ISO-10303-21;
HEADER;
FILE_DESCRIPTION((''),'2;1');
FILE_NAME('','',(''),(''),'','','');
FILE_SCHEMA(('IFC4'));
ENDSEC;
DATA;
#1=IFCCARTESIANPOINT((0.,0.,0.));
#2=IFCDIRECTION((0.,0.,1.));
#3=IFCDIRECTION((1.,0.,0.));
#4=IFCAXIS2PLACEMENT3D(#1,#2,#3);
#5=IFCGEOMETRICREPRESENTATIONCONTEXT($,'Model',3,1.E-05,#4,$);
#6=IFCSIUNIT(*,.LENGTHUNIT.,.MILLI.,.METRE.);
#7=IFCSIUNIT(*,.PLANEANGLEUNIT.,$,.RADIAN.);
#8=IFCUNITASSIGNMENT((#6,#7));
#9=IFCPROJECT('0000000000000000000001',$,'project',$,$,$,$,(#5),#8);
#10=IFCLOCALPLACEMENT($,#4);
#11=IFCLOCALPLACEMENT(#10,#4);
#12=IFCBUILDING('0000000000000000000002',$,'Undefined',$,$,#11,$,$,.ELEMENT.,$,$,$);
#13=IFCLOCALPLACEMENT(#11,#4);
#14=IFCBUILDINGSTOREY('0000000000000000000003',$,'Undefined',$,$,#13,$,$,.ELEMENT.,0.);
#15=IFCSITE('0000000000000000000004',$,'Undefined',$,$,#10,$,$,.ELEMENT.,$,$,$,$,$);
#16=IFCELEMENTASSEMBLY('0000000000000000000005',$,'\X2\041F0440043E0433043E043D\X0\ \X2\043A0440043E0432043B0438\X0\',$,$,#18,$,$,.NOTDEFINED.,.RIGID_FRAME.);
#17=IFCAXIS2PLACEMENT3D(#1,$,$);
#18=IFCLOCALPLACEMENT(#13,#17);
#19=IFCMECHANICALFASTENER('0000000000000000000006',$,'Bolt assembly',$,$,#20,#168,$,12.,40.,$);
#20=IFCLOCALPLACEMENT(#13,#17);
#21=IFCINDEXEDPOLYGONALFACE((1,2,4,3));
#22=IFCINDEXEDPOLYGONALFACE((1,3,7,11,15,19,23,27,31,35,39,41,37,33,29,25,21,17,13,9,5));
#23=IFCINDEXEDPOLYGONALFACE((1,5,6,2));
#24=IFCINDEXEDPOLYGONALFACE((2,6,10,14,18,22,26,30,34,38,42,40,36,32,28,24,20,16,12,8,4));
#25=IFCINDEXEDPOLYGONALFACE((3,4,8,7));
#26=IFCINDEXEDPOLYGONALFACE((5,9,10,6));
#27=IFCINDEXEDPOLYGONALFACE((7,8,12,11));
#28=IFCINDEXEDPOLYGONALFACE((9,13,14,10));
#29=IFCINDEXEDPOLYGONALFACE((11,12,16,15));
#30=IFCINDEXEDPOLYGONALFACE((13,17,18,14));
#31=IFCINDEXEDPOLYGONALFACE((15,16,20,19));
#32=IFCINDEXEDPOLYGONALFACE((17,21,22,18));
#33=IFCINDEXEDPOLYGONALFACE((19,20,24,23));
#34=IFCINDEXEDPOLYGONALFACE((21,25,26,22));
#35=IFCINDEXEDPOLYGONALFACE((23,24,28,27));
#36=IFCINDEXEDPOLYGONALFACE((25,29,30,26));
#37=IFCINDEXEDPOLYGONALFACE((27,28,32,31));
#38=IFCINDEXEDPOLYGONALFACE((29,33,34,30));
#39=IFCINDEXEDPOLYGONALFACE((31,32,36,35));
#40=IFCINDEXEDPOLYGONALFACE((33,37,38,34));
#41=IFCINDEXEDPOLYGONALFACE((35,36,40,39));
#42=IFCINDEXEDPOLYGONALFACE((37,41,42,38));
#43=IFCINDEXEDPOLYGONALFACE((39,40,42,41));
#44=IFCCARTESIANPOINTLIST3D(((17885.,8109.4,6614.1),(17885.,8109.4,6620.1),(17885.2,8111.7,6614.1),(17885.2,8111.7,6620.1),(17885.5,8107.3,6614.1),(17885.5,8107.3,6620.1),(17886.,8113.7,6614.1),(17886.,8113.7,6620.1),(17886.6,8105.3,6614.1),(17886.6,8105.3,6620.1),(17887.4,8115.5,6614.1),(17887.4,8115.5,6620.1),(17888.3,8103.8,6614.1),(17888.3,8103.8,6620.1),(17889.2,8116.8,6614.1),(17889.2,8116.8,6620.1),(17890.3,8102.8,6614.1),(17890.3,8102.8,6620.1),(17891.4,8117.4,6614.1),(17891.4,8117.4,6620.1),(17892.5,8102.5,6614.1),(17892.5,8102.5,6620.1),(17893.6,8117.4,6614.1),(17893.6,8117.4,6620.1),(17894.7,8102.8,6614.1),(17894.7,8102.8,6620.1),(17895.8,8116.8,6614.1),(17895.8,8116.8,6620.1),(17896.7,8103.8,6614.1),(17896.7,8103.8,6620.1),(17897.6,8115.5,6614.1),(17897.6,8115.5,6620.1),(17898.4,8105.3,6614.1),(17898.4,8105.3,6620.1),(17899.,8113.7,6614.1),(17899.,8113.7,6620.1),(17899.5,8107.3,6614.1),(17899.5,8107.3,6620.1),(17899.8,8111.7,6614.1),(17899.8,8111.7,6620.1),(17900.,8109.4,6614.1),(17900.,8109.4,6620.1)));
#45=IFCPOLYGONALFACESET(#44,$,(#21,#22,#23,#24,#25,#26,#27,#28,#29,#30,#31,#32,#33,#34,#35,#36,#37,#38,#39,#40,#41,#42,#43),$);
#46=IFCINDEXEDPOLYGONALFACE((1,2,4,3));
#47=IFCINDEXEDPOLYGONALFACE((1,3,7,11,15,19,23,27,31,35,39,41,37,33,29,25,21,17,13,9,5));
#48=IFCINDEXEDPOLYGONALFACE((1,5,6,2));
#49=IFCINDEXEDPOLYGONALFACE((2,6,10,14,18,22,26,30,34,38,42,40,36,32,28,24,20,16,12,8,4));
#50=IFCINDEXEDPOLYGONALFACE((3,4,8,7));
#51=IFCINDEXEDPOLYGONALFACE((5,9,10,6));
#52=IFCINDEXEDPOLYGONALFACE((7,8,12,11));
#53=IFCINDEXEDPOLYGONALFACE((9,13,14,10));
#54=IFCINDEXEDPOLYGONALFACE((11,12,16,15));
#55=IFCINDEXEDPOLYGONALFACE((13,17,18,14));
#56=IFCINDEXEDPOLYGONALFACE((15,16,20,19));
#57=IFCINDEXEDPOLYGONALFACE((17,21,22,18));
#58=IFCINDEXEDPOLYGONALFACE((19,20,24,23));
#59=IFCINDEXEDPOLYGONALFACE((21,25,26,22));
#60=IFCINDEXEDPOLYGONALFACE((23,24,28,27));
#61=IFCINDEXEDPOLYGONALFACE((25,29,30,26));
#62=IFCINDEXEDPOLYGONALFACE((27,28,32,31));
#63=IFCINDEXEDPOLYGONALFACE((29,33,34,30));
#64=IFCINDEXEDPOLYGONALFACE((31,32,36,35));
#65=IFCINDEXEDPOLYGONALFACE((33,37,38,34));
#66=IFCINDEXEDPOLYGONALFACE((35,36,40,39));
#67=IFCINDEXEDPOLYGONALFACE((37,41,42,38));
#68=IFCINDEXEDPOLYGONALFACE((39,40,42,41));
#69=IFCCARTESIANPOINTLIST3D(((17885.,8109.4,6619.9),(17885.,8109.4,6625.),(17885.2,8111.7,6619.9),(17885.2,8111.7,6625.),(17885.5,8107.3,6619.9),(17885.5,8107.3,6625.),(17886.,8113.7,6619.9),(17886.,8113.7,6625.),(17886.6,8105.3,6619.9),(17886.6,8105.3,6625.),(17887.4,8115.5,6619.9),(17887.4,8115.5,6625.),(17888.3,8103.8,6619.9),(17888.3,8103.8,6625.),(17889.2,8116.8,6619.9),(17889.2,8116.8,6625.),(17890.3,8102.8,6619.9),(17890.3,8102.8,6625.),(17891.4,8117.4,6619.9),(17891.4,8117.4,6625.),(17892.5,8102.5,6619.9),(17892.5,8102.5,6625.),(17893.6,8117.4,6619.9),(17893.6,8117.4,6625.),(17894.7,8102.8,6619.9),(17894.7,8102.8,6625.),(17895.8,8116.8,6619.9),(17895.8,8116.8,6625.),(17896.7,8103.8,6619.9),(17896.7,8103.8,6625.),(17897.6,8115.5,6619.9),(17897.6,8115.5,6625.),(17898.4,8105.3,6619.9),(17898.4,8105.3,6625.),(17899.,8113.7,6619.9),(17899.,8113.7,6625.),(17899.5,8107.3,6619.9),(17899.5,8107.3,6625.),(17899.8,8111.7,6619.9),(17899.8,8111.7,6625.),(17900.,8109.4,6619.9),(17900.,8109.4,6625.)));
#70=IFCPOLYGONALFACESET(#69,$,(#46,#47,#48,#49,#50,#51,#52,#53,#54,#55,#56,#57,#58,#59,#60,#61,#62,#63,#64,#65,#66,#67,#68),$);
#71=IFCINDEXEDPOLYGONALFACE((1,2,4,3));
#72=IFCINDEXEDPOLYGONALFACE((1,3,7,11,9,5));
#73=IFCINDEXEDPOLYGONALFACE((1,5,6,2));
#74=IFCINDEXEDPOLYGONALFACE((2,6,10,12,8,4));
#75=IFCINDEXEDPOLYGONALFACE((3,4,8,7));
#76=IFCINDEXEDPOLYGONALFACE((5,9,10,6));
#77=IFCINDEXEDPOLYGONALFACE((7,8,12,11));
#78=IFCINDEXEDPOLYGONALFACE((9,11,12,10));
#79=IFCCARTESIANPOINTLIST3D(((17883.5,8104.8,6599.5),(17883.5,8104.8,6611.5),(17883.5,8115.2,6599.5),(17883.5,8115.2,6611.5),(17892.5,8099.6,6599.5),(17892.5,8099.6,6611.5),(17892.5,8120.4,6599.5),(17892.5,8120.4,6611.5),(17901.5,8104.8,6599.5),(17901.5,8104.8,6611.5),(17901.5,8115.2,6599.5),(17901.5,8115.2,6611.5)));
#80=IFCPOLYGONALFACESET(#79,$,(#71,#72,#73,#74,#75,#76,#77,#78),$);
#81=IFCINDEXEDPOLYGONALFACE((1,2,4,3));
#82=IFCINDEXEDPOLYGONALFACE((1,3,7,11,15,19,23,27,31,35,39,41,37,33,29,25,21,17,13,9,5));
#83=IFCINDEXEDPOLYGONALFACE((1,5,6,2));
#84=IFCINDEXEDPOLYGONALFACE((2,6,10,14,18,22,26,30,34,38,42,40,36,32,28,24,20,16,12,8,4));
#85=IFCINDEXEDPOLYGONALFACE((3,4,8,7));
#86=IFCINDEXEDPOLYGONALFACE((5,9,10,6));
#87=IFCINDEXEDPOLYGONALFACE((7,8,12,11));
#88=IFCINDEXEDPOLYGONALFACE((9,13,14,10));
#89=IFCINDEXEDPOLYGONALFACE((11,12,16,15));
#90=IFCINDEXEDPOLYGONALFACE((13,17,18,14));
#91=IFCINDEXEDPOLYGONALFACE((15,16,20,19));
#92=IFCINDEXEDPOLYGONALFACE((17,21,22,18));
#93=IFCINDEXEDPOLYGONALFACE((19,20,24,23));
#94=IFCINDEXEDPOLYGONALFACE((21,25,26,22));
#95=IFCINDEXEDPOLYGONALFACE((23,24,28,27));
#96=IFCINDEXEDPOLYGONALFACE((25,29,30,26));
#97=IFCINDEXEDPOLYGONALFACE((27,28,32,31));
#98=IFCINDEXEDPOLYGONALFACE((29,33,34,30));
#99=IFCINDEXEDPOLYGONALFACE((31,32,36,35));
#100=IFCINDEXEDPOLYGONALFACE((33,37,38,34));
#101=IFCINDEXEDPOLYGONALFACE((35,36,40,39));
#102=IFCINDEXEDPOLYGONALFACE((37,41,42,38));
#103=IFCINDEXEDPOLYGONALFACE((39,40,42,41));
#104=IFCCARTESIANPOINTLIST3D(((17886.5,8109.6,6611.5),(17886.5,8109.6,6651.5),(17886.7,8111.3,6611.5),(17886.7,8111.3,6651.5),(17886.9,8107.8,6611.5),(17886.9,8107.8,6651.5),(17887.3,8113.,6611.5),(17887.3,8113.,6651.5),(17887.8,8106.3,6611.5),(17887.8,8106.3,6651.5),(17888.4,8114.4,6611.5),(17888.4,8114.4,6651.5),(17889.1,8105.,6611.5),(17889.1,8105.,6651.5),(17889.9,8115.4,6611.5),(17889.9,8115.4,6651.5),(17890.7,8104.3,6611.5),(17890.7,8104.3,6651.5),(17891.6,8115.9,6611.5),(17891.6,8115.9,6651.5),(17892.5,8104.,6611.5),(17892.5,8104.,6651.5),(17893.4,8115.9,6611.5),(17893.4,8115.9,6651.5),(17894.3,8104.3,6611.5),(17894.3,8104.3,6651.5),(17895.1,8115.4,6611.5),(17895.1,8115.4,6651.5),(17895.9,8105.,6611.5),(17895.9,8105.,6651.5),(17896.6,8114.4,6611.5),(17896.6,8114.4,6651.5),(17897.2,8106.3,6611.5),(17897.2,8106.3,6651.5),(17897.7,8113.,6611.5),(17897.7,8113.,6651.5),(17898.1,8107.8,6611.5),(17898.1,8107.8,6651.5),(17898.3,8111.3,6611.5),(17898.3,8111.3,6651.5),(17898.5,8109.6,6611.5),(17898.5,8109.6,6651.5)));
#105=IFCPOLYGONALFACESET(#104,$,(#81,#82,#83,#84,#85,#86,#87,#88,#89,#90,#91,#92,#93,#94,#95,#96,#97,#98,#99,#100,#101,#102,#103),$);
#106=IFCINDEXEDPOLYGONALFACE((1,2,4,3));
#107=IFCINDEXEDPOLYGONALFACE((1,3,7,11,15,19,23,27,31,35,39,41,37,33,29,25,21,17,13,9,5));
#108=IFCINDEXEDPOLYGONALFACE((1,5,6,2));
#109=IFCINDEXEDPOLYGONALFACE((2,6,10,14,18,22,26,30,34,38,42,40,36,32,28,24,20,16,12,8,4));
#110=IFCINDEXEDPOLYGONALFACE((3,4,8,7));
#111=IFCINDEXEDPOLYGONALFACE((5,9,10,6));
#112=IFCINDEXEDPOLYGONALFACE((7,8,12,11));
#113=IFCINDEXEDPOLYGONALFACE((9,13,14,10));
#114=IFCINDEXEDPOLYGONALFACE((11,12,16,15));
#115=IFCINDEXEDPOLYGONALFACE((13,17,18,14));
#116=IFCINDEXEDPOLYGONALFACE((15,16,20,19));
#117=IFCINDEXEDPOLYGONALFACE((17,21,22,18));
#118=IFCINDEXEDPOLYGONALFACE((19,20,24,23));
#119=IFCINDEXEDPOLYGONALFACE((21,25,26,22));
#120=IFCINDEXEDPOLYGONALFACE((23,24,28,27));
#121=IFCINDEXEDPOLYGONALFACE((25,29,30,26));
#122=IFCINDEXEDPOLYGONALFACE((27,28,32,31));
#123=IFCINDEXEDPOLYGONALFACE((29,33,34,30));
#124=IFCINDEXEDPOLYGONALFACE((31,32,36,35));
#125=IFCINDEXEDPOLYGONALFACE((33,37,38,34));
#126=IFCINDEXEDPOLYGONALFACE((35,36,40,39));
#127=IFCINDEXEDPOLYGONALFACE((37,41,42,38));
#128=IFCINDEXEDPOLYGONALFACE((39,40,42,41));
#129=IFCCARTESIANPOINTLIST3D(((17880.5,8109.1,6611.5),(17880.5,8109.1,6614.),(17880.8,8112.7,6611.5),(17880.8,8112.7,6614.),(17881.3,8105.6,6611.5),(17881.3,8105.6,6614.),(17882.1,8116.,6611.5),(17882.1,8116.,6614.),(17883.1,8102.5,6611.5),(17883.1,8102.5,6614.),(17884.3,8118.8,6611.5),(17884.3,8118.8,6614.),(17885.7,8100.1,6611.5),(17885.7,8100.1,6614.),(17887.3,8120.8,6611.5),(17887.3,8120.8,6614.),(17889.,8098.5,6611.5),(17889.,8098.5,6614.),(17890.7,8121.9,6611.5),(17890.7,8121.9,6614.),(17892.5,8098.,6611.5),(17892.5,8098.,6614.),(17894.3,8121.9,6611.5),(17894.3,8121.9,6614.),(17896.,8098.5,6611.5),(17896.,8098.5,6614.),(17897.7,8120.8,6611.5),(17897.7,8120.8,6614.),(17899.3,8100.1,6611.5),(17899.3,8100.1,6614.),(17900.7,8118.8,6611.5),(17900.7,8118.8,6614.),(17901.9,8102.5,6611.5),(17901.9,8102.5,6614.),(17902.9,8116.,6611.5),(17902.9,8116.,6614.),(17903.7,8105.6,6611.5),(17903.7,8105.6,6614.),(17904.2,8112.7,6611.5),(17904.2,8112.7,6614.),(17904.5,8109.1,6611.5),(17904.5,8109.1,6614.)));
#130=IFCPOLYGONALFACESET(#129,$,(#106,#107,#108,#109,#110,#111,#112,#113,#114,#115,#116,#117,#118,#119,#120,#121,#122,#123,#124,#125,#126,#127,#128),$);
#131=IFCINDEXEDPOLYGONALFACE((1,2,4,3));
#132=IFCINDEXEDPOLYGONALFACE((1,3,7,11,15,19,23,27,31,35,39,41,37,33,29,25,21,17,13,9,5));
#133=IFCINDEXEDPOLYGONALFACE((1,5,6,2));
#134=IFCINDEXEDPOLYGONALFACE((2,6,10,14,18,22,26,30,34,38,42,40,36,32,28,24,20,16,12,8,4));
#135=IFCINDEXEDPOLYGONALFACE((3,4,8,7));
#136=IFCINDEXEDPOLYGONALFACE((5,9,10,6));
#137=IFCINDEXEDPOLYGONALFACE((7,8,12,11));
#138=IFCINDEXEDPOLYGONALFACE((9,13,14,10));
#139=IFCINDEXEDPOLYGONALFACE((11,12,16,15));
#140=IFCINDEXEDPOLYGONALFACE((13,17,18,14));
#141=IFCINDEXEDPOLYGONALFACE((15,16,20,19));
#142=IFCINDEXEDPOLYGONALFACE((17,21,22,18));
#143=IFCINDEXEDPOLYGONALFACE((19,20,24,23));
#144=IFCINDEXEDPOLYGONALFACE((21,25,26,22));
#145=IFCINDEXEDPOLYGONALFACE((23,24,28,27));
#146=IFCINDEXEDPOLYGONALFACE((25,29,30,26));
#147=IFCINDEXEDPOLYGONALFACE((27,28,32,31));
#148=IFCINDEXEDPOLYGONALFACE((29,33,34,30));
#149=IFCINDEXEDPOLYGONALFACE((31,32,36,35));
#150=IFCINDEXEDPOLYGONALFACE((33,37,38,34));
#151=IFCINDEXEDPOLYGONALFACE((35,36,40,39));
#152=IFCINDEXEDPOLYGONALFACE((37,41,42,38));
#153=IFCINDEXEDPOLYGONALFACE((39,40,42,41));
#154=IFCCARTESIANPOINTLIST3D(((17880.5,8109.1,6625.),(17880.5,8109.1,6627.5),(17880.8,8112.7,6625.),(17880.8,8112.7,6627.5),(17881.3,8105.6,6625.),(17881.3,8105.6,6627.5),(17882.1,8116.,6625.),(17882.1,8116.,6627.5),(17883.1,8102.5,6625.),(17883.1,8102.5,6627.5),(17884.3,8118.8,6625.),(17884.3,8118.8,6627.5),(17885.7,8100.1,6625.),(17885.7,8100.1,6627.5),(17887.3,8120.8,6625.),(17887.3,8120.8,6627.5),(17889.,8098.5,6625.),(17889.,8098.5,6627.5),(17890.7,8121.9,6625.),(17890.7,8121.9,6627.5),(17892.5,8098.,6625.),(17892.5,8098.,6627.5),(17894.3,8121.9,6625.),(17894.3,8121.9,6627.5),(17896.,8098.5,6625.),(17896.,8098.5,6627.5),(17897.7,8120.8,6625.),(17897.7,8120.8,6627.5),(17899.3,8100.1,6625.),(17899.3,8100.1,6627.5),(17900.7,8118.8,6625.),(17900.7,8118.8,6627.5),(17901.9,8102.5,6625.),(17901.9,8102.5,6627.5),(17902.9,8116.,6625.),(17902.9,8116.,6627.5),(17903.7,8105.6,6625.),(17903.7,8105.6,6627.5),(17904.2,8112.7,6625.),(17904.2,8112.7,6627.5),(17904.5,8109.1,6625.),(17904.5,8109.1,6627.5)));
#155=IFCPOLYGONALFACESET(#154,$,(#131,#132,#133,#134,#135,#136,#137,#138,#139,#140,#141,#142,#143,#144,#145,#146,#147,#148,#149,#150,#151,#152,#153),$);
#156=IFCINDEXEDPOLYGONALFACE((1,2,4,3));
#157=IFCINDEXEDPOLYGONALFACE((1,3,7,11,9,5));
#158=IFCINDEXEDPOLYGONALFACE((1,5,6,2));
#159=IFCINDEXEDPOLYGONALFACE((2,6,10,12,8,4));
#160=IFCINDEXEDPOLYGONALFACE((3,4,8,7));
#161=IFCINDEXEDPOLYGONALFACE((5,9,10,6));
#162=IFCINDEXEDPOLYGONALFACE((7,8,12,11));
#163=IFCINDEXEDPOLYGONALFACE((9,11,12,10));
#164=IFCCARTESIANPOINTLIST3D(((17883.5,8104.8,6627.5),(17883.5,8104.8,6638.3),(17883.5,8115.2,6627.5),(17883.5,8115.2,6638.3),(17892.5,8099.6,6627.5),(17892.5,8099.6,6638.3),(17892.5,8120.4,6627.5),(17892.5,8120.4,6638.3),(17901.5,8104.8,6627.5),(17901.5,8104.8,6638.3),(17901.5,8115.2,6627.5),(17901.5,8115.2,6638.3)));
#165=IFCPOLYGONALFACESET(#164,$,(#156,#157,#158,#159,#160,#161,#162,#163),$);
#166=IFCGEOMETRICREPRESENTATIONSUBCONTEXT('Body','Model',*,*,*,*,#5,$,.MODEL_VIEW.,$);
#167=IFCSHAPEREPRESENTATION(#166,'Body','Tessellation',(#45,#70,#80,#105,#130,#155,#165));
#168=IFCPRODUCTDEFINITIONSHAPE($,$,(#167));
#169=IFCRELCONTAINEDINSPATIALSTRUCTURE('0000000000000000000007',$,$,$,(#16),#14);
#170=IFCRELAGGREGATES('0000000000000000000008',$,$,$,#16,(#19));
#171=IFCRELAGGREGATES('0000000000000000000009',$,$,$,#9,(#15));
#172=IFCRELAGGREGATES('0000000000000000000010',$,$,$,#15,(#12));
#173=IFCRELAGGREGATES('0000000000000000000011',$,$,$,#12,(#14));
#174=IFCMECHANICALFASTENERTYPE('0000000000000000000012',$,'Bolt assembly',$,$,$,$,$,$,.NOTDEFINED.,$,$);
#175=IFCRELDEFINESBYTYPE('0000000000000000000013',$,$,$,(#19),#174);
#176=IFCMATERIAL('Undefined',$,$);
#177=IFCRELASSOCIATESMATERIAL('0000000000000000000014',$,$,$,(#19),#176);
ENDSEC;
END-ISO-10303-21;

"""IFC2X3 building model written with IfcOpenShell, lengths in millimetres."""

from ifc_helpers import new_model, si_unit, frame, origin_with_axes, origin_2d_with_axis, place, context, subcontext, project, spatial, polyline, circle, outline, extrude, source, transform, mapped, material, type_object, element, aggregate, save


model = new_model("IFC2X3")

# Units and contexts
model_context = context("Model", 3, precision=1e-05, world=origin_with_axes())
body_context = subcontext(model_context, "Body", "Model", "MODEL_VIEW")
ifc_project = project(units=[si_unit("LENGTHUNIT", "METRE", prefix="MILLI"), si_unit("PLANEANGLEUNIT", "RADIAN")], contexts=[model_context])

# Site, building, storey
site_placement = place(None, origin_with_axes())
site = spatial("IfcSite", under=ifc_project, at=site_placement, Name="Undefined", CompositionType="ELEMENT")
building_placement = place(site_placement, origin_with_axes())
building = spatial("IfcBuilding", under=site, at=building_placement, Name="Undefined", CompositionType="ELEMENT")
storey_placement = place(building_placement, origin_with_axes())
storey = spatial("IfcBuildingStorey", under=building, at=storey_placement, Name="Undefined", CompositionType="ELEMENT", Elevation=0.0)

# Element assembly
assembly_1_placement = place(storey_placement, origin_with_axes())
assembly_1 = element("IfcElementAssembly", 1, at=assembly_1_placement, inside=storey, Name="Прогон кровли", AssemblyPlace="NOTDEFINED", PredefinedType="RIGID_FRAME")

# Mechanical fastener
ifc_material_1 = material(Name="Undefined")
mechanical_fastener_type = type_object("IfcMechanicalFastenerType", Name="Bolt assembly")
shared_shape_1 = source(origin_with_axes(), body_context, "Body", "SweptSolid", [
    extrude(circle(Radius=7.5, at=origin_2d_with_axis()), frame((0.0, -5.9, 0.0), z_axis=(0.0, 1.0, 0.0), x_axis=(1.0, 0.0, 0.0)), (0.0, 0.0, 1.0), 6.0),
    extrude(circle(Radius=7.5, at=origin_2d_with_axis()), frame((0.0, -0.1, 0.0), z_axis=(0.0, 1.0, 0.0), x_axis=(1.0, 0.0, 0.0)), (0.0, 0.0, 1.0), 5.1),
    extrude(outline(polyline([(10.4, 0.0), (5.2, 9.0), (-5.2, 9.0), (-10.4, 0.0), (-5.2, -9.0), (5.2, -9.0), (10.4, 0.0)])), frame((0.0, -20.5, 0.0), z_axis=(0.0, 1.0, 0.0), x_axis=(1.0, 0.0, 0.0)), (0.0, 0.0, 1.0), 12.0),
    extrude(circle(Radius=6.0, at=origin_2d_with_axis()), frame((0.0, -8.5, 0.0), z_axis=(0.0, 1.0, 0.0), x_axis=(1.0, 0.0, 0.0)), (0.0, 0.0, 1.0), 40.0),
    extrude(circle(Radius=12.0, at=origin_2d_with_axis()), frame((0.0, -8.5, 0.0), z_axis=(0.0, 1.0, 0.0), x_axis=(1.0, 0.0, 0.0)), (0.0, 0.0, 1.0), 2.5),
    extrude(circle(Radius=12.0, at=origin_2d_with_axis()), frame((0.0, 5.0, 0.0), z_axis=(0.0, 1.0, 0.0), x_axis=(1.0, 0.0, 0.0)), (0.0, 0.0, 1.0), 2.5),
    extrude(outline(polyline([(10.4, 0.0), (5.2, 9.0), (-5.2, 9.0), (-10.4, 0.0), (-5.2, -9.0), (5.2, -9.0), (10.4, 0.0)])), frame((0.0, 7.5, 0.0), z_axis=(0.0, 1.0, 0.0), x_axis=(1.0, 0.0, 0.0)), (0.0, 0.0, 1.0), 10.8),
])
mechanical_fastener_1_placement = place(assembly_1_placement, frame((17892.5, 8110.0, 6620.0), z_axis=(-1.0, 0.0, 0.0), x_axis=(0.0, -1.0, 0.0)))
mechanical_fastener_1 = element("IfcMechanicalFastener", 2, at=mechanical_fastener_1_placement, type_object=mechanical_fastener_type, material=ifc_material_1, Name="Bolt assembly", NominalDiameter=12.0, NominalLength=40.0, context=body_context, shape_type="MappedRepresentation", body=[
    mapped(shared_shape_1, transform((0.0, 0.0, 0.0))),
])
aggregate(assembly_1, [mechanical_fastener_1])

save(model, "model.ifc")
